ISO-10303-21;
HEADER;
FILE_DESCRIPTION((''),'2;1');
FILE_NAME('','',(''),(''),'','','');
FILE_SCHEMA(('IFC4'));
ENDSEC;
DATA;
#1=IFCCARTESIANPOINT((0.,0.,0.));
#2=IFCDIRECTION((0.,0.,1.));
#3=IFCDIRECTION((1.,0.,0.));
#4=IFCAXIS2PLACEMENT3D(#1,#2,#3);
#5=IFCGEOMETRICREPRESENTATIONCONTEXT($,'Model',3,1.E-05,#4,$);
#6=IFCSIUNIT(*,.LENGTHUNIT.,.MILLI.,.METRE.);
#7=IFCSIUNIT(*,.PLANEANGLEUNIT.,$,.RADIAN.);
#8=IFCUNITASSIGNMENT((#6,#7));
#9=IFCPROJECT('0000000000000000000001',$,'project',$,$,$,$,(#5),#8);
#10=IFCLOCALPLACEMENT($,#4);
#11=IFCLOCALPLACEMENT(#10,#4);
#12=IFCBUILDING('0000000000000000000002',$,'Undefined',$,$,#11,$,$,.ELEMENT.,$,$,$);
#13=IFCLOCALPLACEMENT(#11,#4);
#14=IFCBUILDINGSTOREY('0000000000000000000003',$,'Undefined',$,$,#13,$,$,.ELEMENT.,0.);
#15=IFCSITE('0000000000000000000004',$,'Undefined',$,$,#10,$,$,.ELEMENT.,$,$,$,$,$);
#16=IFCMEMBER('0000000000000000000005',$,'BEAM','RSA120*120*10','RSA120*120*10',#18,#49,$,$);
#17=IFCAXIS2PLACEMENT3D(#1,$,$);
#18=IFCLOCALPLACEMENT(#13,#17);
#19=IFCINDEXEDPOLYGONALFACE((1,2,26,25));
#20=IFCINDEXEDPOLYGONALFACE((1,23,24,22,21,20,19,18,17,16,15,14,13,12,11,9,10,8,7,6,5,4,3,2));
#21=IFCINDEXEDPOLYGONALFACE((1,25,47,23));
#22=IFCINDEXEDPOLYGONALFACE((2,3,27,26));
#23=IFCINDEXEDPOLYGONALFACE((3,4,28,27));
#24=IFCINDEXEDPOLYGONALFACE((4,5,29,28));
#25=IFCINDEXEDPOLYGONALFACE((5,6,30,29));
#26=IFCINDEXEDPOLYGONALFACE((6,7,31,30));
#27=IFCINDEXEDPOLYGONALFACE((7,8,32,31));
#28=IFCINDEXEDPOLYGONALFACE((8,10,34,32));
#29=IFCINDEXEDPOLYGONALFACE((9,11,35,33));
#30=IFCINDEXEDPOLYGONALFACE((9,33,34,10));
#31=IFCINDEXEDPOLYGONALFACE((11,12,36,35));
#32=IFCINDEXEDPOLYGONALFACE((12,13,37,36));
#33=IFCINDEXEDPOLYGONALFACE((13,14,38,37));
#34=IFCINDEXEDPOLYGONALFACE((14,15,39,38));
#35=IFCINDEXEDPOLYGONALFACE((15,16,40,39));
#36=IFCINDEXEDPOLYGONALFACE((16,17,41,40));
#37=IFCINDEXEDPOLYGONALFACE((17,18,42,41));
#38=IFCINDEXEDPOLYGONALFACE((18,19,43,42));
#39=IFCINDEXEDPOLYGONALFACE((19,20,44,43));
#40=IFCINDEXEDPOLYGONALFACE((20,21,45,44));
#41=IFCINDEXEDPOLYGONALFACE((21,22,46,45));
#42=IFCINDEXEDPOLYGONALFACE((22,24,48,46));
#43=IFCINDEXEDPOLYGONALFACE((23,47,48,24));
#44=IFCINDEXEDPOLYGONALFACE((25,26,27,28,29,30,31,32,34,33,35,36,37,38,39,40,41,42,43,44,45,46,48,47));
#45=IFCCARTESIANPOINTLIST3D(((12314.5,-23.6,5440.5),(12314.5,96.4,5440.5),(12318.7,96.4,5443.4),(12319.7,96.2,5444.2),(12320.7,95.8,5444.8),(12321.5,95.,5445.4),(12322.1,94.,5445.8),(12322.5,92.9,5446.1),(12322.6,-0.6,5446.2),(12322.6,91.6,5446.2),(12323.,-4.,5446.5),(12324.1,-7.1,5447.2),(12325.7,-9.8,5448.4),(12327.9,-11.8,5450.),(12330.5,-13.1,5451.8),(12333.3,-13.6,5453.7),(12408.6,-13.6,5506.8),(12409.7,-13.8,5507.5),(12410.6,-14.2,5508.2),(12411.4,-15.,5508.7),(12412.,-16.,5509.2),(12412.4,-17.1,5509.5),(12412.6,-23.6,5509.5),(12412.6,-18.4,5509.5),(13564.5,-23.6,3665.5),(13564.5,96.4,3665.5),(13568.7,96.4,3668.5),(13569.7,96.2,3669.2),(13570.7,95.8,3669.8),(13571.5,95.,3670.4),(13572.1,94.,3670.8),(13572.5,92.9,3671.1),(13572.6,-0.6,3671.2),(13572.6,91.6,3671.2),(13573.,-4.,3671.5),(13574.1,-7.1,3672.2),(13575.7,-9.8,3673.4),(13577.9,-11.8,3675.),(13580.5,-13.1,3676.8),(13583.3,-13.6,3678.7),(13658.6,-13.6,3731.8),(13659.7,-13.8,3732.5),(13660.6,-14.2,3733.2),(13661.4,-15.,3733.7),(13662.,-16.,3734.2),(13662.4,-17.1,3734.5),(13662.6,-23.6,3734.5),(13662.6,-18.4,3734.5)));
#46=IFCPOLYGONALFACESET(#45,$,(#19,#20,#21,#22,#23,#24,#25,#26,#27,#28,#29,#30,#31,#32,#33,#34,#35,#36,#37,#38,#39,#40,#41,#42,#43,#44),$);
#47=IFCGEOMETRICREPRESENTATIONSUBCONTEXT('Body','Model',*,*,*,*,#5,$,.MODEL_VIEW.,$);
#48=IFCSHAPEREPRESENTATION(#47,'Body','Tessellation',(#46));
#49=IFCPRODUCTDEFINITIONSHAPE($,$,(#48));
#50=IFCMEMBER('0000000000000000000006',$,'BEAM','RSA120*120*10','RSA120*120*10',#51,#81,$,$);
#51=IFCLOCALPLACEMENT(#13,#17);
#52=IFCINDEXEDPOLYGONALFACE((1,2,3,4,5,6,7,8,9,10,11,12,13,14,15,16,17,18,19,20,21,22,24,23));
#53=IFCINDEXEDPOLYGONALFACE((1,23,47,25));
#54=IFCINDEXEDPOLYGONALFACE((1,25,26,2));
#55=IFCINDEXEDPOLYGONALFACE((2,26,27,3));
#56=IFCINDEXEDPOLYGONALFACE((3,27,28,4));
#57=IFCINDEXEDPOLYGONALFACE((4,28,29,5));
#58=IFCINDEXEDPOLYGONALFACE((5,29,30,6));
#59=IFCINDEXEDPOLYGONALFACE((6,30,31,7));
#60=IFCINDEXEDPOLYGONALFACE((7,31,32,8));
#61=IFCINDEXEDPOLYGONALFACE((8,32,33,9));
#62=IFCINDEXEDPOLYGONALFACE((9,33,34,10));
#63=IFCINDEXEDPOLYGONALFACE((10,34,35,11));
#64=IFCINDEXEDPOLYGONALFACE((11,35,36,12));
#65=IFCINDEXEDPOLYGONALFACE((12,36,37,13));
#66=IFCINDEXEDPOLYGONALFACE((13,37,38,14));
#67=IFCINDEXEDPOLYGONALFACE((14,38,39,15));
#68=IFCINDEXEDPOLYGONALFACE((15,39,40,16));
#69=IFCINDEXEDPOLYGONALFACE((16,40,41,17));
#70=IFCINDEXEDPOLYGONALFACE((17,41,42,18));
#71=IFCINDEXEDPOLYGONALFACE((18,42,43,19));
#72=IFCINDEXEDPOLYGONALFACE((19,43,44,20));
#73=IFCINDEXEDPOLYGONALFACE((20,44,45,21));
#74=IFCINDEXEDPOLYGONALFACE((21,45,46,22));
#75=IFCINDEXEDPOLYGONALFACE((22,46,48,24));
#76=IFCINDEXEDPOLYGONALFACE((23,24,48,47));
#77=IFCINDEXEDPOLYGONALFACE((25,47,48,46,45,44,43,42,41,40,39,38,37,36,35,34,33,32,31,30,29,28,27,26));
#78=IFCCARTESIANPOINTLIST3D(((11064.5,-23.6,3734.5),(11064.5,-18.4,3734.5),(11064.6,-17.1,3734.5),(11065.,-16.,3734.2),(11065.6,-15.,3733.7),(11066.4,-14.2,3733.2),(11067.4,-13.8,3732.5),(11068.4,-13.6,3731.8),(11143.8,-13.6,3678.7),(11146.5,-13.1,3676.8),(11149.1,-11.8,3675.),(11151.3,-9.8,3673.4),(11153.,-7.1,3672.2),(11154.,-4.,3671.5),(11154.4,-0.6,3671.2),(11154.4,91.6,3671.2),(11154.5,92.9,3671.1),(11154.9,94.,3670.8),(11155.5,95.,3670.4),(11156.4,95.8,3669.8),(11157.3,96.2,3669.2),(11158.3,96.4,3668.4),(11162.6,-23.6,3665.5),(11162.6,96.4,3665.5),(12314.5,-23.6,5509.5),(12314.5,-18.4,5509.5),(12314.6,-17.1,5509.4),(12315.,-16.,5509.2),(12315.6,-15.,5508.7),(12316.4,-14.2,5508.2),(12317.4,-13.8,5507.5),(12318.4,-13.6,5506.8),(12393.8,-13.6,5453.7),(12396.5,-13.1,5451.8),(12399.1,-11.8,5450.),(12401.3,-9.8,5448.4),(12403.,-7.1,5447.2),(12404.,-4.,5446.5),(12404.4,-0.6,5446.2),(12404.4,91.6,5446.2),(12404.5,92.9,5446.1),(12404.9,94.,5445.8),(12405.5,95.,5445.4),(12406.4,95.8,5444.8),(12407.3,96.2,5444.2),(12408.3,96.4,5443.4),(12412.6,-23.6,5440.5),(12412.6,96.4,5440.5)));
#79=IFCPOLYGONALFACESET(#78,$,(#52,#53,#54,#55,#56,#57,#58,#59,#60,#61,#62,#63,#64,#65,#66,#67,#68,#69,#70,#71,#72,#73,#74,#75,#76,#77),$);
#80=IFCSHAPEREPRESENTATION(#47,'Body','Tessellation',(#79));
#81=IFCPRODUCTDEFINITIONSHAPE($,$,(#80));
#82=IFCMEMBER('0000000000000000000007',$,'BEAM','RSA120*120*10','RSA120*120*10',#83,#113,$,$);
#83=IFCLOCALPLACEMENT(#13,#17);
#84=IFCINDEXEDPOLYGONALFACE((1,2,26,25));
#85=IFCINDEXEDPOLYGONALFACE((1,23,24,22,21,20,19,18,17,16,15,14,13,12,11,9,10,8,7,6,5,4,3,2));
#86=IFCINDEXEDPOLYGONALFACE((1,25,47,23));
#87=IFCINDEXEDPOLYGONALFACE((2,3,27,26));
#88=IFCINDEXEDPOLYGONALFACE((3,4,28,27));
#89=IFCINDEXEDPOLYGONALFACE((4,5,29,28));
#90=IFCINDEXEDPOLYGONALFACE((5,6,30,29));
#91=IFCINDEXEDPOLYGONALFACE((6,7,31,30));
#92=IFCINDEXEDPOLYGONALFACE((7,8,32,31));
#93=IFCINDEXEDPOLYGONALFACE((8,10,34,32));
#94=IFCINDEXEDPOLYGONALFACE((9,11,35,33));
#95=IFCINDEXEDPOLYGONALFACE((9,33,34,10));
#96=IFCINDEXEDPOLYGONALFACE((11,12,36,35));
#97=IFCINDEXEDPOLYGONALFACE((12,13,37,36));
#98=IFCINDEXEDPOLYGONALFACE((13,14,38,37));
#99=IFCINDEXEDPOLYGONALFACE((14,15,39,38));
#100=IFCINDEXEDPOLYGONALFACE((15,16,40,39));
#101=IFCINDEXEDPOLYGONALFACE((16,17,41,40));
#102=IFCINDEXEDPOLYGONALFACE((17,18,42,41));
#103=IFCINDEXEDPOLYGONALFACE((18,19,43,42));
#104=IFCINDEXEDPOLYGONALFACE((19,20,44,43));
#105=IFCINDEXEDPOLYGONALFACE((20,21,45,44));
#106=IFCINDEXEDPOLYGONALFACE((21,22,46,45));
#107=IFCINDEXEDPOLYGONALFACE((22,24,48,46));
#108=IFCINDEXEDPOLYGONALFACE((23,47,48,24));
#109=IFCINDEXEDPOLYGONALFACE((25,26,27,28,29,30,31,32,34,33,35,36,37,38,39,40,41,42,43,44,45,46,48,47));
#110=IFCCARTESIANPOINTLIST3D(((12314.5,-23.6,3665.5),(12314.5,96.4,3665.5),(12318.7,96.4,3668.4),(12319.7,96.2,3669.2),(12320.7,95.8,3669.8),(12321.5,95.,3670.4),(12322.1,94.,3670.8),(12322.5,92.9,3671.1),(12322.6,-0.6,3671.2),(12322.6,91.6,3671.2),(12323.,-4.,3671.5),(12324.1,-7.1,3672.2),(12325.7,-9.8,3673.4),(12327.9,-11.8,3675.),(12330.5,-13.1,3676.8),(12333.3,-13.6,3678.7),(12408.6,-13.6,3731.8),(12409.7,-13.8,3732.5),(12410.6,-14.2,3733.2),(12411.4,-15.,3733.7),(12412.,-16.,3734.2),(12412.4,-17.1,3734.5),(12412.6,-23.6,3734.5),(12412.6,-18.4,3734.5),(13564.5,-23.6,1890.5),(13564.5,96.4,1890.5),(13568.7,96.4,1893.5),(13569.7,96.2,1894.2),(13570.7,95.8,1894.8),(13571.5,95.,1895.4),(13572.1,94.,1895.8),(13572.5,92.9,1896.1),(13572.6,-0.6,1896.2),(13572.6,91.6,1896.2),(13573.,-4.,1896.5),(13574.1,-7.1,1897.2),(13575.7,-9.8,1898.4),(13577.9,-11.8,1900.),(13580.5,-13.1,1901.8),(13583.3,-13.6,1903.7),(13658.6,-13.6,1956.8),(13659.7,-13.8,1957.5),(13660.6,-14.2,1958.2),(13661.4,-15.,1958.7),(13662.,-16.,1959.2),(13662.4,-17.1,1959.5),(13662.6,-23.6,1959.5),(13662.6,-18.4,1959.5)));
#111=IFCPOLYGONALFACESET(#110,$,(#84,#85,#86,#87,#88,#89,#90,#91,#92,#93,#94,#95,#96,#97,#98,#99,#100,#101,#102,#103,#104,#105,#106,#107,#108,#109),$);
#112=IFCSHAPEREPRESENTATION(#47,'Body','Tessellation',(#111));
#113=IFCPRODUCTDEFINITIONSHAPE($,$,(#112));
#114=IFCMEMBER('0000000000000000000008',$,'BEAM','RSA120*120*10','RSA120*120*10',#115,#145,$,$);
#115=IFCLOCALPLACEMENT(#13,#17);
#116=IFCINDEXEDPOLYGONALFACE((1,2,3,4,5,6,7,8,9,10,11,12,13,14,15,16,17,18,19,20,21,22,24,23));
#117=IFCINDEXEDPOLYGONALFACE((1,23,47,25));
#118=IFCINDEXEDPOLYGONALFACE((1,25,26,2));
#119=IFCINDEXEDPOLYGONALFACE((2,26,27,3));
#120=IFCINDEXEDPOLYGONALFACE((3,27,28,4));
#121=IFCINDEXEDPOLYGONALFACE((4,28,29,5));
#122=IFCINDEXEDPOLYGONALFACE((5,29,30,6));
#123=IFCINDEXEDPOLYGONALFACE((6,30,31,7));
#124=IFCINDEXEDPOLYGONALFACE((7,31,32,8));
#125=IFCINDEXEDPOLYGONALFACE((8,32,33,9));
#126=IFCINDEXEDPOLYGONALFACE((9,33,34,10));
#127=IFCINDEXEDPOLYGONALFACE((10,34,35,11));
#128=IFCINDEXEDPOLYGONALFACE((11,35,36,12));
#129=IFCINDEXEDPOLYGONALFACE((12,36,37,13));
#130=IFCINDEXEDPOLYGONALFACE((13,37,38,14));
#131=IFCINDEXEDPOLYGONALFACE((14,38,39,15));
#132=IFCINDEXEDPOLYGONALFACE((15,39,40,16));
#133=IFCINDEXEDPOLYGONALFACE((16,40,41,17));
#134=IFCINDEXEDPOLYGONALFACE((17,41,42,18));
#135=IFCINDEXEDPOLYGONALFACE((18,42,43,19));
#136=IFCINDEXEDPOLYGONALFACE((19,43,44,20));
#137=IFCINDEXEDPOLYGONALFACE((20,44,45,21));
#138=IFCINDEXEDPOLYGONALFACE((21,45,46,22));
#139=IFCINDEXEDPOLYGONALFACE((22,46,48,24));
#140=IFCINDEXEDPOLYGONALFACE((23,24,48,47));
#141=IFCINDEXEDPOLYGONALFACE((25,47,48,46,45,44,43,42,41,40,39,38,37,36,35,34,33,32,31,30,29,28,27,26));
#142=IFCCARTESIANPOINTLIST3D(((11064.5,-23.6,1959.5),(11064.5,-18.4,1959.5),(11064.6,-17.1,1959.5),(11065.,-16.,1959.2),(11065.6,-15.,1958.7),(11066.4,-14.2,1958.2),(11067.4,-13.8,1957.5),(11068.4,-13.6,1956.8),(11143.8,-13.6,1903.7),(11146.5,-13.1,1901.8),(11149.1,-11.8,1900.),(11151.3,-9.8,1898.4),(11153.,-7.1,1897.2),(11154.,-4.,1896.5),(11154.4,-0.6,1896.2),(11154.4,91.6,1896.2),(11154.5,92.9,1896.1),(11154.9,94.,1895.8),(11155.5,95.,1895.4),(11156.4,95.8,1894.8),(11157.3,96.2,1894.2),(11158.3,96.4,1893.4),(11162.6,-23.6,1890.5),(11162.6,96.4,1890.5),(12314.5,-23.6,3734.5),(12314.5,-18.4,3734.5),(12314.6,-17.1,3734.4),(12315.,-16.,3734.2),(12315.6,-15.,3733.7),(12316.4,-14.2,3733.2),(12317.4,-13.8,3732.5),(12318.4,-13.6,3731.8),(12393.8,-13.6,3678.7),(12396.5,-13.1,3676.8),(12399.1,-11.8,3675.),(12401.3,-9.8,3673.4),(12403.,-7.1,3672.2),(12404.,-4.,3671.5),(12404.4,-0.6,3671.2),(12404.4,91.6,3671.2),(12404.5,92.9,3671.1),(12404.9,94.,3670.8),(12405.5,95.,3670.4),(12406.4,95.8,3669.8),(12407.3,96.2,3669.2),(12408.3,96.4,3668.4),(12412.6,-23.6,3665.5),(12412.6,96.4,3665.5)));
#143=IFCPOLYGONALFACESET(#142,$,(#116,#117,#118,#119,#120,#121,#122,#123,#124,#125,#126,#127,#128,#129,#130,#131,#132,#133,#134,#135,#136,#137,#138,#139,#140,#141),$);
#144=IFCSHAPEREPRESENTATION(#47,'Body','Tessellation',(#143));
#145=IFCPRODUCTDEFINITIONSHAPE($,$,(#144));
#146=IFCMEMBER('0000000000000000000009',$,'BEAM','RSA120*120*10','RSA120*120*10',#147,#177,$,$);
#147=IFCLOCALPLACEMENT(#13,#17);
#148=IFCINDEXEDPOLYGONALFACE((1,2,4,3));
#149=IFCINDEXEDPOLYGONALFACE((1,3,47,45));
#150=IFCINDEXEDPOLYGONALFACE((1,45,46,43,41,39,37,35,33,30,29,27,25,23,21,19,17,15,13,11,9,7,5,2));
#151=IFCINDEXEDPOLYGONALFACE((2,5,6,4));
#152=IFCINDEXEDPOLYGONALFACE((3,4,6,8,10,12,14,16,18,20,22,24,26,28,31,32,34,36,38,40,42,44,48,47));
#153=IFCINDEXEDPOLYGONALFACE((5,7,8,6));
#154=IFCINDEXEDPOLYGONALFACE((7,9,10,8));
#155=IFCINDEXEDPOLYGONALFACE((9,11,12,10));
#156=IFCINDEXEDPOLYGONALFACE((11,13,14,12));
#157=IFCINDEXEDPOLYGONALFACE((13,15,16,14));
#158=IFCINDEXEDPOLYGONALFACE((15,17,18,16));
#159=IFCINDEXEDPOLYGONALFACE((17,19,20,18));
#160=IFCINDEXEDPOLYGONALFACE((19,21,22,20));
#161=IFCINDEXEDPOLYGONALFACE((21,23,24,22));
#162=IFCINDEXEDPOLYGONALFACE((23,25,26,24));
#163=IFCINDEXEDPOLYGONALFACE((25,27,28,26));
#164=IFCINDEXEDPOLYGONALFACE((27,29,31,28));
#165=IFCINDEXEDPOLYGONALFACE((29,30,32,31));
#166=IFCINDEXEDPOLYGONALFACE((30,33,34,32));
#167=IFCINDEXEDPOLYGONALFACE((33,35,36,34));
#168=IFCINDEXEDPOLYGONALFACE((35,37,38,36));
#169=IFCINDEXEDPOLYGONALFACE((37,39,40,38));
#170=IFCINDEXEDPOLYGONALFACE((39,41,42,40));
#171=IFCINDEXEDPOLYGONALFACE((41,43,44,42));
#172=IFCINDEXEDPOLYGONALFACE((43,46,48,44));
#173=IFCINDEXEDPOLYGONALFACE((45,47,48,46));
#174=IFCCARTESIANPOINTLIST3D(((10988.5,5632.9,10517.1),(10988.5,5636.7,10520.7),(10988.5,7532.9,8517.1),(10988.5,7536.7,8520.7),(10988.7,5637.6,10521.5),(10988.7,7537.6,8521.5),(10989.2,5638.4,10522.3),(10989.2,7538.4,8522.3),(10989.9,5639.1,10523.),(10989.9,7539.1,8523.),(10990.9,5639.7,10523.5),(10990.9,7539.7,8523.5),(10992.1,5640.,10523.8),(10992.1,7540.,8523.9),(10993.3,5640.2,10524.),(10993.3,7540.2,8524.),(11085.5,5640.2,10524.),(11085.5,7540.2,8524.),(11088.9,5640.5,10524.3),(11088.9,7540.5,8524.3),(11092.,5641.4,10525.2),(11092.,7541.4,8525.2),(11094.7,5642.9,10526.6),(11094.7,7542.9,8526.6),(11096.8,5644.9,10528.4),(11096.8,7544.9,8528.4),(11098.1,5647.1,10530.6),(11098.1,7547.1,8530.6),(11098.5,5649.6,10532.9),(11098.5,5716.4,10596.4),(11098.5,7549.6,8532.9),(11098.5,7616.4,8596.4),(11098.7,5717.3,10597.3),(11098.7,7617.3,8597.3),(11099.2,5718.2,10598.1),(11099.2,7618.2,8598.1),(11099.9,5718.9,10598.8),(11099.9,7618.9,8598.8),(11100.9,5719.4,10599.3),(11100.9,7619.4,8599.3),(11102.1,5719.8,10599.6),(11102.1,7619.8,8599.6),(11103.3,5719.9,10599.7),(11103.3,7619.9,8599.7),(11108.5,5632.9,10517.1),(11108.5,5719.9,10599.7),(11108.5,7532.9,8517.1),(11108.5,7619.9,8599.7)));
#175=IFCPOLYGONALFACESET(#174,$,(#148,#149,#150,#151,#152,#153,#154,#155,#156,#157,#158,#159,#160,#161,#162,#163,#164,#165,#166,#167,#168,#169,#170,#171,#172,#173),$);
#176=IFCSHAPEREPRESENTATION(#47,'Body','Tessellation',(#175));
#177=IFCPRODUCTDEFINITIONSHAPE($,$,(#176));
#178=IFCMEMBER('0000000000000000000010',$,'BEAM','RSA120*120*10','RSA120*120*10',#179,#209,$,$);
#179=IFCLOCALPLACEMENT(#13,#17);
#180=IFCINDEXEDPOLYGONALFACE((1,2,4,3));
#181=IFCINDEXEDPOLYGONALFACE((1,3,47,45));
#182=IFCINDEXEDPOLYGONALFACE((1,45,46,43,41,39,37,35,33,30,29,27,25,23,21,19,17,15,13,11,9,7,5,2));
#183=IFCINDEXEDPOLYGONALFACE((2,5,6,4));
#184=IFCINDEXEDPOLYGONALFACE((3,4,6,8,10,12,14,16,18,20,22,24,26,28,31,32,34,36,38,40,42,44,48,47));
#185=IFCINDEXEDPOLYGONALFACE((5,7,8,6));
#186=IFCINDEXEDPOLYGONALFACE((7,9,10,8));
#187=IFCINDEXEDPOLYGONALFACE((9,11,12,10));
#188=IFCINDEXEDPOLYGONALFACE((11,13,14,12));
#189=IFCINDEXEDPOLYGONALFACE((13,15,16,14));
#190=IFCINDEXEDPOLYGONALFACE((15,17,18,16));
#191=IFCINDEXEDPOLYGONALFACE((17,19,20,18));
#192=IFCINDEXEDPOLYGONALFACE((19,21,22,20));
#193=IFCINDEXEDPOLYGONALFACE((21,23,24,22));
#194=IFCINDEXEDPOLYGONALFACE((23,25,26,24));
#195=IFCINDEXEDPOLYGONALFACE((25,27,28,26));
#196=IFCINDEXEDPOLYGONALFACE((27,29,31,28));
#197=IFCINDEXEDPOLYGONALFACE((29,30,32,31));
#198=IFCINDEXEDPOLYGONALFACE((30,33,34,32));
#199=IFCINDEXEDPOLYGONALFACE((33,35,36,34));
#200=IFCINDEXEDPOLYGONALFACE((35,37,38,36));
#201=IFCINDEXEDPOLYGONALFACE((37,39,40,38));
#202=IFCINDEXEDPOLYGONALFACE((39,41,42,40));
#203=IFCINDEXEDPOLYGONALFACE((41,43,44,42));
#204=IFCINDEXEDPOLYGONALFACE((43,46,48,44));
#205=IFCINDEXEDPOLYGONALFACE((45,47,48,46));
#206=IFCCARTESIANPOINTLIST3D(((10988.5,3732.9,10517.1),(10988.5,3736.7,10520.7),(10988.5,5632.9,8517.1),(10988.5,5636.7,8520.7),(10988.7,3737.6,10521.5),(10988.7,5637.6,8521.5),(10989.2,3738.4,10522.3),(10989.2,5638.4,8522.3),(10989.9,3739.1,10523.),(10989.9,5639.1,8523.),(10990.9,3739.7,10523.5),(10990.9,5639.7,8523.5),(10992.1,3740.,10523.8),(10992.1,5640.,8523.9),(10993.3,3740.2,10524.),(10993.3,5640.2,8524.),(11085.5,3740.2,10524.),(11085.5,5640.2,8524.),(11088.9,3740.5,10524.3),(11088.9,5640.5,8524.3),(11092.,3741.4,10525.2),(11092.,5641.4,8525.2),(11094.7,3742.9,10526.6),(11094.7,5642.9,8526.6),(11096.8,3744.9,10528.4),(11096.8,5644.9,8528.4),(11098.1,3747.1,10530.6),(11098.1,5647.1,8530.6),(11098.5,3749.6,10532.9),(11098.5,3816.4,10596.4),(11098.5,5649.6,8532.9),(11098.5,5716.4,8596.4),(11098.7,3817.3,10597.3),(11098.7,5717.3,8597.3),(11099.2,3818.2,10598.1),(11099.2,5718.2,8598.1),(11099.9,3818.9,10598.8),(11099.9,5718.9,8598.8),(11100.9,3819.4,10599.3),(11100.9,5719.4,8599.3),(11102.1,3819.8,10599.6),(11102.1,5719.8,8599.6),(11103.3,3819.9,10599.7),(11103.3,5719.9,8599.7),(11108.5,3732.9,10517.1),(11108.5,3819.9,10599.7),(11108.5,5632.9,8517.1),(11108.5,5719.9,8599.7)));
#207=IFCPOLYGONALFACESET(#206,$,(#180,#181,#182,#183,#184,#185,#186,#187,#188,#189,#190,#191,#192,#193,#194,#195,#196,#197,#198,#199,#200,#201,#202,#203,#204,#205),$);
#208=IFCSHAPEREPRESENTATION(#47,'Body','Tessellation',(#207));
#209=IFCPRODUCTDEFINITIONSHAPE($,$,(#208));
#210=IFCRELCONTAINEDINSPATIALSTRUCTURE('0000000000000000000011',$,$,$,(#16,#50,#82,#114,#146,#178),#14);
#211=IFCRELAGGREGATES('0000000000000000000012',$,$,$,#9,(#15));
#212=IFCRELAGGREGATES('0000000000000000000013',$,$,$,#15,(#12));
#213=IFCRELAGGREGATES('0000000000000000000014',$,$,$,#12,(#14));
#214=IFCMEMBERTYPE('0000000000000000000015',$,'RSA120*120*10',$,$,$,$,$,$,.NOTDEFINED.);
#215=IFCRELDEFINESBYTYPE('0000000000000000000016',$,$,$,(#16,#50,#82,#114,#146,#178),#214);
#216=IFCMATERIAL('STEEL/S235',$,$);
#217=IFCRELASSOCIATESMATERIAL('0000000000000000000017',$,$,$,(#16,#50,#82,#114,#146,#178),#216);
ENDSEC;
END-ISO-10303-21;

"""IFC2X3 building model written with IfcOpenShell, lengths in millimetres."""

from ifc_helpers import new_model, si_unit, frame, origin_with_axes, origin_2d_with_axis, place, context, subcontext, project, spatial, l_section, extrude, material, type_object, element, save


model = new_model("IFC2X3")

# Units and contexts
model_context = context("Model", 3, precision=1e-05, world=origin_with_axes())
body_context = subcontext(model_context, "Body", "Model", "MODEL_VIEW")
ifc_project = project(units=[si_unit("LENGTHUNIT", "METRE", prefix="MILLI"), si_unit("PLANEANGLEUNIT", "RADIAN")], contexts=[model_context])

# Site, building, storey
site_placement = place(None, origin_with_axes())
site = spatial("IfcSite", under=ifc_project, at=site_placement, Name="Undefined", CompositionType="ELEMENT")
building_placement = place(site_placement, origin_with_axes())
building = spatial("IfcBuilding", under=site, at=building_placement, Name="Undefined", CompositionType="ELEMENT")
storey_placement = place(building_placement, origin_with_axes())
storey = spatial("IfcBuildingStorey", under=building, at=storey_placement, Name="Undefined", CompositionType="ELEMENT", Elevation=0.0)

# Shared definitions
ifc_material = material(Name="STEEL/S235")

# Members
member_type_1 = type_object("IfcMemberType", Name="RSA120*120*10", PredefinedType="NOTDEFINED")
for number, where, z_axis, x_axis, name in (
    (1, (13613.5, 36.4, 3700.0), (0.817606, 0.0, 0.575779), (-0.575779, 0.0, 0.817606), "BEAM"),
    (2, (12363.5, 36.4, 5475.0), (-0.817606, 0.0, 0.575779), (-0.575779, 0.0, -0.817606), "BEAM"),
    (3, (13613.5, 36.4, 1925.0), (0.817606, 0.0, 0.575779), (-0.575779, 0.0, 0.817606), "BEAM"),
    (4, (12363.5, 36.4, 3700.0), (-0.817606, 0.0, 0.575779), (-0.575779, 0.0, -0.817606), "BEAM"),
):
    element("IfcMember", number, at=place(storey_placement, frame(where, z_axis=z_axis, x_axis=x_axis)), inside=storey, type_object=member_type_1, material=ifc_material, Name=name, Description="RSA120*120*10", ObjectType="RSA120*120*10", context=body_context, shape_type="SweptSolid", body=[
        extrude(l_section(Depth=120.0, Width=120.0, Thickness=10.0, FilletRadius=13.0, EdgeRadius=4.8, at=origin_2d_with_axis()), frame((2171.0, 0.0, 0.0), z_axis=(-1.0, 0.0, 0.0), x_axis=(0.0, -1.0, 0.0)), (0.0, 0.0, 1.0), 2171.0),
    ])
for number, where, z_axis, x_axis, name in (
    (5, (11048.5, 7576.4, 8558.4), (0.0, 0.724999, 0.688749), (0.0, -0.688749, 0.724999), "BEAM"),
    (6, (11048.5, 5676.4, 8558.4), (0.0, 0.724999, 0.688749), (0.0, -0.688749, 0.724999), "BEAM"),
):
    element("IfcMember", number, at=place(storey_placement, frame(where, z_axis=z_axis, x_axis=x_axis)), inside=storey, type_object=member_type_1, material=ifc_material, Name=name, Description="RSA120*120*10", ObjectType="RSA120*120*10", context=body_context, shape_type="SweptSolid", body=[
        extrude(l_section(Depth=120.0, Width=120.0, Thickness=10.0, FilletRadius=13.0, EdgeRadius=4.8, at=origin_2d_with_axis()), frame((2758.6, 0.0, 0.0), z_axis=(-1.0, 0.0, 0.0), x_axis=(0.0, -1.0, 0.0)), (0.0, 0.0, 1.0), 2758.6),
    ])

save(model, "model.ifc")
